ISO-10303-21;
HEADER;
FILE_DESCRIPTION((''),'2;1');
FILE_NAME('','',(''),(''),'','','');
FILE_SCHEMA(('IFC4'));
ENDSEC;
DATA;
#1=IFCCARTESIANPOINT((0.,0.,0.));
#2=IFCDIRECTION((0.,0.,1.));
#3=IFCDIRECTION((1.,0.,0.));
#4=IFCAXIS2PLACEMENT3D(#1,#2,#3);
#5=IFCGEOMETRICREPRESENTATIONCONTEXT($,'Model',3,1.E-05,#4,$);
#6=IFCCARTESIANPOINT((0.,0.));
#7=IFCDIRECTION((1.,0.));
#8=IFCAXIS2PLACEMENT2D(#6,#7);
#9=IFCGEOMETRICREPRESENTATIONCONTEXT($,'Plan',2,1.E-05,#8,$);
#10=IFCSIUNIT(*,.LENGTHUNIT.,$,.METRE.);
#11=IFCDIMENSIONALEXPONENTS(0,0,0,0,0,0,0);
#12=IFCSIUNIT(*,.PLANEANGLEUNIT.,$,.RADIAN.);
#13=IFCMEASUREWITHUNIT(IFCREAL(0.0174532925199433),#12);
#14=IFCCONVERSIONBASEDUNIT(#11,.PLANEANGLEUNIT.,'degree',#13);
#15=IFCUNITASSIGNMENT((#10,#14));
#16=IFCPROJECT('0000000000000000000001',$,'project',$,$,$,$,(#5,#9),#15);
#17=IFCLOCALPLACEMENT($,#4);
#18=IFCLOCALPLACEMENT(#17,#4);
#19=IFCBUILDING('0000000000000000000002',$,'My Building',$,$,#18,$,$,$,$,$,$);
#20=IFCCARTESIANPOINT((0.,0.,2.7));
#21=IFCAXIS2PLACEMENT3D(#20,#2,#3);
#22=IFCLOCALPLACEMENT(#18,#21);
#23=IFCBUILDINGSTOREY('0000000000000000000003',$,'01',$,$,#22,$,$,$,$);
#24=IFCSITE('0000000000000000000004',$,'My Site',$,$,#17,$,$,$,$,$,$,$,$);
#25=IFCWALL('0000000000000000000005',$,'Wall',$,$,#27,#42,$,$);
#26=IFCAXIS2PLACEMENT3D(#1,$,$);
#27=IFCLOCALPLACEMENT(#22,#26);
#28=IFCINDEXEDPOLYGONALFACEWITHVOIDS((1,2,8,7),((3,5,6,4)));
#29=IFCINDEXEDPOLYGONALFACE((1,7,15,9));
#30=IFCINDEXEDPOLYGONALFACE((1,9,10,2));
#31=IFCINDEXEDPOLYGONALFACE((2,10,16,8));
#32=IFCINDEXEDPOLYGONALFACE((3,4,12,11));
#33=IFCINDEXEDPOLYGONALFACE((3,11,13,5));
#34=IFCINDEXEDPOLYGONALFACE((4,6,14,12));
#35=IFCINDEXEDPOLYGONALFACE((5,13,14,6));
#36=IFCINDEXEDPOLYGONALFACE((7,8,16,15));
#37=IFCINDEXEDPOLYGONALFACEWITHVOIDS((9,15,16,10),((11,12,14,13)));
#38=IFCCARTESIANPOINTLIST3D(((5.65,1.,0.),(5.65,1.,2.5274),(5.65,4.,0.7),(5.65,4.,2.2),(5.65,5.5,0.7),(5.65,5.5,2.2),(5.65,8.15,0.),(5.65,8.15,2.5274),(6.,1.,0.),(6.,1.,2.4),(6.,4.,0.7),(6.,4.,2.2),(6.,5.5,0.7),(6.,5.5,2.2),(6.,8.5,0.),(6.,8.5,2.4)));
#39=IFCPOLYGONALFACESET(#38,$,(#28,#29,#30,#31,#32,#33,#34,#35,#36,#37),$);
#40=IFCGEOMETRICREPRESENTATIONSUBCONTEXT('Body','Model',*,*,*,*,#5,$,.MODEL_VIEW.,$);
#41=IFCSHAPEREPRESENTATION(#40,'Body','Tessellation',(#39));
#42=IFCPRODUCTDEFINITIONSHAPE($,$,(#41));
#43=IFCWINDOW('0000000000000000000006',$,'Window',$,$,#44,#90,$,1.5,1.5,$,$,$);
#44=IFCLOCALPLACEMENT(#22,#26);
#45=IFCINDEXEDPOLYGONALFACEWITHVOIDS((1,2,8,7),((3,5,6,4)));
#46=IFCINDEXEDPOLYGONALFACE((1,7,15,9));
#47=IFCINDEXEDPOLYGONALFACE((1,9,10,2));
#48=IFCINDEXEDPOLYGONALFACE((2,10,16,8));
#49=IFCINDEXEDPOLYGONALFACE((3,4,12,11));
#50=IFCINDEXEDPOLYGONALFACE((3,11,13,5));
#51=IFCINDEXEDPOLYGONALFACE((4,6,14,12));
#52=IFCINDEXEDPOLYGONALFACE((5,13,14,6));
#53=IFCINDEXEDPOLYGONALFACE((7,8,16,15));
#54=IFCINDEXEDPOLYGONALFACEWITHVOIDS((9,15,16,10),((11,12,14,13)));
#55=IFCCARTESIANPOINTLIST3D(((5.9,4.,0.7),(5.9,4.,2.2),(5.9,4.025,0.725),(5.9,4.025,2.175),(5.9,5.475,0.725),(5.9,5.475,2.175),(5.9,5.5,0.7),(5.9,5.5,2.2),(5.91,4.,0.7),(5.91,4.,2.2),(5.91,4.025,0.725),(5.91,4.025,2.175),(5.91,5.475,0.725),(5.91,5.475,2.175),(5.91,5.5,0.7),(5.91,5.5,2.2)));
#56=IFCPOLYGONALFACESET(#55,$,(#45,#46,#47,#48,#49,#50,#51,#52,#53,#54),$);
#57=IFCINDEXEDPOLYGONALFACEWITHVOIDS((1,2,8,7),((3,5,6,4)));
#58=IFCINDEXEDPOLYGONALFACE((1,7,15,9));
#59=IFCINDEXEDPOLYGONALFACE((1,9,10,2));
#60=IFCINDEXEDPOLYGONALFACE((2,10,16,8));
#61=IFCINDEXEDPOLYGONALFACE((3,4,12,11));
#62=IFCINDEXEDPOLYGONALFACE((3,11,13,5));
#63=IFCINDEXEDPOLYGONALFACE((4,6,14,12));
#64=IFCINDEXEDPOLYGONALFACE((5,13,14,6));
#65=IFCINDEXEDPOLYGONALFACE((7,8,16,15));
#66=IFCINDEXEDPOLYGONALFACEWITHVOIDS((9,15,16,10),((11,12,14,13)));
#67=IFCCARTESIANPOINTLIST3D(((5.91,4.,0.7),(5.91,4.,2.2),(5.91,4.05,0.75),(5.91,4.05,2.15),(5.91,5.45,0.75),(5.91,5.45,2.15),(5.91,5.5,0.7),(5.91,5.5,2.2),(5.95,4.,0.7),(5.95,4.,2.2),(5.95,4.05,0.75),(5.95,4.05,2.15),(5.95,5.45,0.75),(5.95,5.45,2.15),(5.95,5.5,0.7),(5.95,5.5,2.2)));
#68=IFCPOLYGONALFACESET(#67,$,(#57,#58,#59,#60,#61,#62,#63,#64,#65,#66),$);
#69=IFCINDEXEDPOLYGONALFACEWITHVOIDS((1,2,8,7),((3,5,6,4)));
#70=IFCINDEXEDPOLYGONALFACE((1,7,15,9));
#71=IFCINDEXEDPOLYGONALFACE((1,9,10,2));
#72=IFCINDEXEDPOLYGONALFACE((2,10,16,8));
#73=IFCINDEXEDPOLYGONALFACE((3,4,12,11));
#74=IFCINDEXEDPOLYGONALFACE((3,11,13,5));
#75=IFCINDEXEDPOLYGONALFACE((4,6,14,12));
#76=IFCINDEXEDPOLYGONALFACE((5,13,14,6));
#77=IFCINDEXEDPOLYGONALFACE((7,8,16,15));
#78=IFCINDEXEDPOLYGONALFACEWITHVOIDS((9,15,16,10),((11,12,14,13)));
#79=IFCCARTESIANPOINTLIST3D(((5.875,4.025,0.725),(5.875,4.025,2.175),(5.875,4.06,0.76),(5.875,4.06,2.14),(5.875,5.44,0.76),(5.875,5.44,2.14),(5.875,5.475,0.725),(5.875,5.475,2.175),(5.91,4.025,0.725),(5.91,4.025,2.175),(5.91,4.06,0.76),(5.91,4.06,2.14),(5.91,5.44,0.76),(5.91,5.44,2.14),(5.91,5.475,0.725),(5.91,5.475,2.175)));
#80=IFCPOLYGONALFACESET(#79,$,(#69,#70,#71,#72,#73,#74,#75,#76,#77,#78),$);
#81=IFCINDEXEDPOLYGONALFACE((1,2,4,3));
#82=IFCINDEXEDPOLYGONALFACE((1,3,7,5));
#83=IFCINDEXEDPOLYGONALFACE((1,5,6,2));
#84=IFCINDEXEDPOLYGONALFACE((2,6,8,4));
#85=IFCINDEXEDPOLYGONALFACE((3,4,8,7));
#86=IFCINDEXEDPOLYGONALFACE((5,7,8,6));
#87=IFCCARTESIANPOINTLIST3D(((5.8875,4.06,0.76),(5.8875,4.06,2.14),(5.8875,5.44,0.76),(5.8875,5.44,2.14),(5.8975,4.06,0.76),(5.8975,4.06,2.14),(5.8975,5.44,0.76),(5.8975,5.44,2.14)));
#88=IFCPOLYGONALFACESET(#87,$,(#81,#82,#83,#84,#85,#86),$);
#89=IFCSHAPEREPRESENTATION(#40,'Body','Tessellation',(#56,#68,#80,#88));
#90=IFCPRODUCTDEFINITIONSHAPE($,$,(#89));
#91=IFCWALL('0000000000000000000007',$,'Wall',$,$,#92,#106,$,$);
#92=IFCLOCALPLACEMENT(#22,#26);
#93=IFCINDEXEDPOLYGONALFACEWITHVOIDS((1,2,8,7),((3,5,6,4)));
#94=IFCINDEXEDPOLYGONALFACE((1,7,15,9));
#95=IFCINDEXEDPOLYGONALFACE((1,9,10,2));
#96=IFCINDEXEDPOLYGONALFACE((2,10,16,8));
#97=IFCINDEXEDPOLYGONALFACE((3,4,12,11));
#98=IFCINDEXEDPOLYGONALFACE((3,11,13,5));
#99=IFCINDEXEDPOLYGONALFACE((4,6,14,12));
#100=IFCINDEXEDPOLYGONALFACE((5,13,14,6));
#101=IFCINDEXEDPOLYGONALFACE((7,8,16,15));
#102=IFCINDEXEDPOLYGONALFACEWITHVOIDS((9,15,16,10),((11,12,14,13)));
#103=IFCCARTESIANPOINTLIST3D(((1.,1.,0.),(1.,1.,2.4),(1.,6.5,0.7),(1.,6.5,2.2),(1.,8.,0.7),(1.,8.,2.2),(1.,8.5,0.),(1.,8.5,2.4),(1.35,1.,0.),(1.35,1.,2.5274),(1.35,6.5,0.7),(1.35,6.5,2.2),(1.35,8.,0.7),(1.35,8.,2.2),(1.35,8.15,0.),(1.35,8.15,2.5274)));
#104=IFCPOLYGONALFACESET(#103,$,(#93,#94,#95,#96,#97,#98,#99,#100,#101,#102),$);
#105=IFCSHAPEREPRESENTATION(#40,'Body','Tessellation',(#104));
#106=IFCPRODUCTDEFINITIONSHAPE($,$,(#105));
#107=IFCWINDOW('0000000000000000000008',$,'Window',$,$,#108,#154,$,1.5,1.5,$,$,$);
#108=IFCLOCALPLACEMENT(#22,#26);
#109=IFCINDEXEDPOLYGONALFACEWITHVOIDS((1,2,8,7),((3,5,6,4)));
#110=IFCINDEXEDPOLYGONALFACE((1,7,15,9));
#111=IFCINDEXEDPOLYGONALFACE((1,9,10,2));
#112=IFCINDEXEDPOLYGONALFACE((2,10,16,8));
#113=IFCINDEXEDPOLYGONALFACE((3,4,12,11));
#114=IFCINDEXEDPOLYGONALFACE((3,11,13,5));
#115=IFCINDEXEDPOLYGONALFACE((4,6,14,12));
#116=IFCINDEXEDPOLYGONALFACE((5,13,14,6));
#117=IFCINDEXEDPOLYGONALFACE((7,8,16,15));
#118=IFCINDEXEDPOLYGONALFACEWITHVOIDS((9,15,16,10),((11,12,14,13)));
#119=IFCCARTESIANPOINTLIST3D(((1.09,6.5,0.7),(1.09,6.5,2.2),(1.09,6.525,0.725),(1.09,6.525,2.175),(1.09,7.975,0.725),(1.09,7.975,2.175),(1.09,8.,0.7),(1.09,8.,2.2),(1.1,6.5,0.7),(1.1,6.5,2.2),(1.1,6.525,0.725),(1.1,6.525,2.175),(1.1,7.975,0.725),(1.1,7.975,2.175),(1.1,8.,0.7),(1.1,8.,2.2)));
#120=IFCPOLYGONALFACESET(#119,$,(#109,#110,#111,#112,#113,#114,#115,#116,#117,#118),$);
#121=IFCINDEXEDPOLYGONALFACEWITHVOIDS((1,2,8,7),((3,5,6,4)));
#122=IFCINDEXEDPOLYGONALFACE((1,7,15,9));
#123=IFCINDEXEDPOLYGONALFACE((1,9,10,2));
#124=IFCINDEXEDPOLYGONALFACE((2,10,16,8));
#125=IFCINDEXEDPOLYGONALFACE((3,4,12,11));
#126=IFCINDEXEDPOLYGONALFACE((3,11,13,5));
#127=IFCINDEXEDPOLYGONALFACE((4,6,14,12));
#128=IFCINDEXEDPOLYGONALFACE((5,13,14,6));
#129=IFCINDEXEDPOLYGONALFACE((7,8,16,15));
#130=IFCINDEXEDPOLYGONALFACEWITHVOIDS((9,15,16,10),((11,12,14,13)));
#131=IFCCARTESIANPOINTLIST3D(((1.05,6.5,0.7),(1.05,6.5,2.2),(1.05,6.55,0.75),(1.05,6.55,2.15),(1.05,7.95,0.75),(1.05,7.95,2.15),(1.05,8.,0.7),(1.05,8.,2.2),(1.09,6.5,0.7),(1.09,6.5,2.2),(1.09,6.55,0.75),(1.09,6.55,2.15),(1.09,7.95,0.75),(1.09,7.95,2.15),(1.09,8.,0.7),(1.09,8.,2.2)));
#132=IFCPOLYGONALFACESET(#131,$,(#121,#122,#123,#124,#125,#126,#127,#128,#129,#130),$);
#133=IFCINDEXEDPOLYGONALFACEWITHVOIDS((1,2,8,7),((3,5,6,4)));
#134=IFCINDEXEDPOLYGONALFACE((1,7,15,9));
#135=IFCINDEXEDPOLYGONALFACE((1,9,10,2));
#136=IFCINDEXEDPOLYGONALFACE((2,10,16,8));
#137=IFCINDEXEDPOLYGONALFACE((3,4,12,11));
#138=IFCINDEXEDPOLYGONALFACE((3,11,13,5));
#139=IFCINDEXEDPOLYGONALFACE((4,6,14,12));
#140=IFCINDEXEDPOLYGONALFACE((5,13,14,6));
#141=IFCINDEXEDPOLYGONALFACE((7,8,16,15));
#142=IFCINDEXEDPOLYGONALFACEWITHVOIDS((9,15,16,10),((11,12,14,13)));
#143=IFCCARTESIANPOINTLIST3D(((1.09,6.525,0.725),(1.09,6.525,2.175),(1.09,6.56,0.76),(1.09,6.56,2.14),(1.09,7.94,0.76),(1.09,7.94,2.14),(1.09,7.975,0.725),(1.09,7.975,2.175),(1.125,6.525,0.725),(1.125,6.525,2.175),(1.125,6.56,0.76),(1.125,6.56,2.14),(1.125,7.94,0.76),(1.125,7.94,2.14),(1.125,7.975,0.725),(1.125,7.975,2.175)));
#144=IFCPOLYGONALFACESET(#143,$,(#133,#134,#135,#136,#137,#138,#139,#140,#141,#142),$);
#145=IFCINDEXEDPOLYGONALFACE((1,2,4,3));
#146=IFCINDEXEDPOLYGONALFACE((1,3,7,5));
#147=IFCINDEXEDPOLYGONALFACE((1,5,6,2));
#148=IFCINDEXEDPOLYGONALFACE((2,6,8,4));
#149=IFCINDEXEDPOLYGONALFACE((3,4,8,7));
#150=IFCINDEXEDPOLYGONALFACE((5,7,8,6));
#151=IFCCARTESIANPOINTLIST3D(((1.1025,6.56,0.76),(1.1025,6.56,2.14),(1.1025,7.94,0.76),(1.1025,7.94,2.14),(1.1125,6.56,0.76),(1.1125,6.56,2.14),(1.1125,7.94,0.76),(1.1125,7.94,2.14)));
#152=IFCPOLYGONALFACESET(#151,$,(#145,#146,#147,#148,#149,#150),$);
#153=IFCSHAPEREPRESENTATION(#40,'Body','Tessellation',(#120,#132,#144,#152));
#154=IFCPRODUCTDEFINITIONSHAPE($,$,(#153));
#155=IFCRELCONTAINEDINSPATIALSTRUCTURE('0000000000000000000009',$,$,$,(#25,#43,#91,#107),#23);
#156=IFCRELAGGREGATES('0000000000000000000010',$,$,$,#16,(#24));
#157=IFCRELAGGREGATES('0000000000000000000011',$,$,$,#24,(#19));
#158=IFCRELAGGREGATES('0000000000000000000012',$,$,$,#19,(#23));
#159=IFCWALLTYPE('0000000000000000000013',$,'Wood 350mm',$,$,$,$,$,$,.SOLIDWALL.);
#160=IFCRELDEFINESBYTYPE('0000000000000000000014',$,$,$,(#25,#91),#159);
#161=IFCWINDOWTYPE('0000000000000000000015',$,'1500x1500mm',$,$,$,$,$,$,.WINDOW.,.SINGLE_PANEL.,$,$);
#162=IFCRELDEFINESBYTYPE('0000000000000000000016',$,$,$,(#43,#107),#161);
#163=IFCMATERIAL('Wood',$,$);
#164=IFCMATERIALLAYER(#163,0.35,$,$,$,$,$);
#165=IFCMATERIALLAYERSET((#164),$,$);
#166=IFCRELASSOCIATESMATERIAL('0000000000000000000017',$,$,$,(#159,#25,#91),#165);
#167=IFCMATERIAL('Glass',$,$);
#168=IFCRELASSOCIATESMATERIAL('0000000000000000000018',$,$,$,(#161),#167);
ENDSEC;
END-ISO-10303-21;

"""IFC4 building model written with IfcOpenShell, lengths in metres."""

from ifc_helpers import new_model, entity, si_unit, converted_unit, frame, origin_with_axes, origin_2d_with_axis, place, context, subcontext, project, spatial, line, indexed_curve, outline, extrude, clip, halfspace, shape, source, transform, mapped, material, layer, layer_set, layer_usage, type_object, type_shapes, element, fill, save


model = new_model("IFC4")

# Units and contexts
model_context = context("Model", 3, precision=1e-05, world=origin_with_axes())
plan_context = context("Plan", 2, precision=1e-05, world=origin_2d_with_axis())
body_context_1 = subcontext(model_context, "Body", "Model", "MODEL_VIEW")
body_context_2 = subcontext(plan_context, "Body", "Plan", "PLAN_VIEW")
ifc_project = project(units=[si_unit("LENGTHUNIT", "METRE"), converted_unit("PLANEANGLEUNIT", "degree", entity("IfcReal", 0.0174532925199433), si_unit("PLANEANGLEUNIT", "RADIAN"), dimensions=[0, 0, 0, 0, 0, 0, 0])], contexts=[model_context, plan_context])

# Site, building, storey
site_placement = place(None, origin_with_axes())
site = spatial("IfcSite", under=ifc_project, at=site_placement, Name="My Site")
building_placement = place(site_placement, origin_with_axes())
building = spatial("IfcBuilding", under=site, at=building_placement, Name="My Building")
storey_placement = place(building_placement, frame((0.0, 0.0, 2.7), z_axis=(0.0, 0.0, 1.0), x_axis=(1.0, 0.0, 0.0)))
storey = spatial("IfcBuildingStorey", under=building, at=storey_placement, Name="01")

# Shared definitions
ifc_material_1 = material(Name="Wood")

# Walls, openings, windows
ifc_layer_1 = layer(ifc_material_1, 0.35)
ifc_layer_set_1 = layer_set([ifc_layer_1])
ifc_layer_usage_1 = layer_usage(ifc_layer_set_1, "AXIS2", "POSITIVE", 0.0)
wall_type = type_object("IfcWallType", Name="Wood 350mm", PredefinedType="SOLIDWALL", material=ifc_layer_set_1)
wall_1_placement = place(storey_placement, frame((6.0, 1.0, 0.0), z_axis=(0.0, 0.0, 1.0), x_axis=(0.0, 1.0, 0.0)))
wall_1 = element("IfcWall", 1, at=wall_1_placement, inside=storey, type_object=wall_type, material=ifc_layer_usage_1, Name="Wall", context=body_context_1, shape_type="Clipping", body=[
    clip(clip(extrude(outline(indexed_curve([(0.0, 0.0), (0.0, 0.35), (7.5, 0.35), (7.5, 0.0), (0.0, 0.0)], self_intersect=False)), origin_with_axes(), (0.0, 0.0, 1.0), 2.7), halfspace(frame((0.0, 0.0, 2.4), z_axis=(0.0, -0.34202, 0.939693), x_axis=(0.0, -0.939693, -0.34202)), False)), halfspace(frame((7.5, 0.0, -2.7), z_axis=(0.707107, 0.707107, 0.0), x_axis=(0.707107, -0.707107, 0.0)), False)),
])
shared_shape_1 = source(origin_with_axes(), body_context_1, "Body", "SweptSolid", [
    extrude(outline(indexed_curve([(0.0, 0.0), (1.5, 0.0), (1.5, 1.5), (0.0, 1.5)], segments=[line(1, 2, 3, 4, 1)])), frame((0.0, -0.6, 0.0), z_axis=(0.0, -1.0, 0.0), x_axis=(1.0, 0.0, 0.0)), (0.0, 0.0, -1.0), 1.2),
])
opening_1_placement = place(wall_1_placement, frame((3.0, 0.0, 0.7), z_axis=(0.0, 0.0, 1.0), x_axis=(1.0, 0.0, 0.0)))
opening_1 = element("IfcOpeningElement", 2, at=opening_1_placement, cuts=wall_1, PredefinedType="OPENING", context=body_context_1, shape_type="MappedRepresentation", body=[
    mapped(shared_shape_1, transform((0.0, 0.0, 0.0), x_axis=(1.0, 0.0, 0.0), y_axis=(0.0, 1.0, 0.0), z_axis=(0.0, 0.0, 1.0), scale=1.0)),
])
ifc_material_2 = material(Name="Glass")
window_type = type_object("IfcWindowType", Name="1500x1500mm", PartitioningType="SINGLE_PANEL", PredefinedType="WINDOW", material=ifc_material_2)
shared_shape_2 = source(origin_with_axes(), body_context_1, "Body", "SweptSolid", [
    extrude(outline(indexed_curve([(0.0, 0.0), (1.5, 0.0), (1.5, 1.5), (0.0, 1.5)], segments=[line(1, 2, 3, 4, 1)]), holes=[indexed_curve([(0.025, 0.025), (1.475, 0.025), (1.475, 1.475), (0.025, 1.475)], segments=[line(1, 2, 3, 4, 1)])]), frame((0.0, 0.09, 0.0), z_axis=(0.0, -1.0, 0.0), x_axis=(1.0, 0.0, 0.0)), (0.0, 0.0, -1.0), 0.01),
    extrude(outline(indexed_curve([(0.0, 0.0), (1.5, 0.0), (1.5, 1.5), (0.0, 1.5)], segments=[line(1, 2, 3, 4, 1)]), holes=[indexed_curve([(0.05, 0.05), (1.45, 0.05), (1.45, 1.45), (0.05, 1.45)], segments=[line(1, 2, 3, 4, 1)])]), frame((0.0, 0.05, 0.0), z_axis=(0.0, -1.0, 0.0), x_axis=(1.0, 0.0, 0.0)), (0.0, 0.0, -1.0), 0.04),
    extrude(outline(indexed_curve([(0.0, 0.0), (1.45, 0.0), (1.45, 1.45), (0.0, 1.45)], segments=[line(1, 2, 3, 4, 1)]), holes=[indexed_curve([(0.035, 0.035), (1.415, 0.035), (1.415, 1.415), (0.035, 1.415)], segments=[line(1, 2, 3, 4, 1)])]), frame((0.025, 0.09, 0.025), z_axis=(0.0, -1.0, 0.0), x_axis=(1.0, 0.0, 0.0)), (0.0, 0.0, -1.0), 0.035),
    extrude(outline(indexed_curve([(0.035, 0.035), (1.415, 0.035), (1.415, 1.415), (0.035, 1.415)], segments=[line(1, 2, 3, 4, 1)])), frame((0.025, 0.1025, 0.025), z_axis=(0.0, -1.0, 0.0), x_axis=(1.0, 0.0, 0.0)), (0.0, 0.0, -1.0), 0.01),
])
shared_shape_3 = source(origin_with_axes(), body_context_2, "Body", "Curve2D", [
    entity("IfcIndexedPolyCurve", entity("IfcCartesianPointList2D", [[0.05, 0.05], [1.45, 0.05]])),
    entity("IfcIndexedPolyCurve", entity("IfcCartesianPointList2D", [[0.0, 0.1], [0.025, 0.1], [0.025, 0.09], [0.05, 0.09], [0.05, 0.05], [0.0, 0.05]]), [entity("IfcLineIndex", [1, 2, 3, 4, 5, 6, 1])]),
    entity("IfcIndexedPolyCurve", entity("IfcCartesianPointList2D", [[1.5, 0.1], [1.475, 0.1], [1.475, 0.09], [1.45, 0.09], [1.45, 0.05], [1.5, 0.05]]), [entity("IfcLineIndex", [1, 2, 3, 4, 5, 6, 1])]),
    entity("IfcIndexedPolyCurve", entity("IfcCartesianPointList2D", [[0.025, 0.09], [0.06, 0.09], [0.06, 0.125], [0.025, 0.125]]), [entity("IfcLineIndex", [1, 2, 3, 4, 1])]),
    entity("IfcIndexedPolyCurve", entity("IfcCartesianPointList2D", [[1.475, 0.09], [1.44, 0.09], [1.44, 0.125], [1.475, 0.125]]), [entity("IfcLineIndex", [1, 2, 3, 4, 1])]),
    entity("IfcIndexedPolyCurve", entity("IfcCartesianPointList2D", [[0.06, 0.09], [1.44, 0.09]])),
    entity("IfcIndexedPolyCurve", entity("IfcCartesianPointList2D", [[0.06, 0.125], [1.44, 0.125]])),
    entity("IfcIndexedPolyCurve", entity("IfcCartesianPointList2D", [[0.06, 0.1075], [1.44, 0.1075]])),
])
type_shapes(window_type, [shared_shape_2, shared_shape_3])
window_1_placement = place(opening_1_placement, frame((0.0, 0.0, 0.0), z_axis=(0.0, 0.0, 1.0), x_axis=(1.0, 0.0, 0.0)))
window_1 = element("IfcWindow", 3, at=window_1_placement, inside=storey, type_object=window_type, Name="Window", OverallHeight=1.5, OverallWidth=1.5, shapes=[
    shape(body_context_1, "Body", "MappedRepresentation", [mapped(shared_shape_2, transform((0.0, 0.0, 0.0), x_axis=(1.0, 0.0, 0.0), y_axis=(0.0, 1.0, 0.0), z_axis=(0.0, 0.0, 1.0), scale=1.0))]),
    shape(body_context_2, "Body", "MappedRepresentation", [mapped(shared_shape_3, transform((0.0, 0.0, 0.0), x_axis=(1.0, 0.0, 0.0), y_axis=(0.0, 1.0, 0.0), z_axis=(0.0, 0.0, 1.0), scale=1.0))]),
])
fill(opening_1, window_1)
ifc_layer_usage_2 = layer_usage(ifc_layer_set_1, "AXIS2", "POSITIVE", 0.0)
wall_2_placement = place(storey_placement, frame((1.0, 8.5, 0.0), z_axis=(0.0, 0.0, 1.0), x_axis=(0.0, -1.0, 0.0)))
wall_2 = element("IfcWall", 4, at=wall_2_placement, inside=storey, type_object=wall_type, material=ifc_layer_usage_2, Name="Wall", context=body_context_1, shape_type="Clipping", body=[
    clip(clip(extrude(outline(indexed_curve([(0.0, 0.0), (0.0, 0.35), (7.5, 0.35), (7.5, 0.0), (0.0, 0.0)], self_intersect=False)), origin_with_axes(), (0.0, 0.0, 1.0), 2.7), halfspace(frame((7.5, 0.0, 2.4), z_axis=(0.0, -0.34202, 0.939693), x_axis=(0.0, 0.939693, 0.34202)), False)), halfspace(frame((0.0, 0.0, -2.7), z_axis=(-0.707106, 0.707107, 0.0), x_axis=(0.707107, 0.707106, 0.0)), False)),
])
opening_2_placement = place(wall_2_placement, frame((0.5, 0.0, 0.7), z_axis=(0.0, 0.0, 1.0), x_axis=(1.0, 0.0, 0.0)))
opening_2 = element("IfcOpeningElement", 5, at=opening_2_placement, cuts=wall_2, PredefinedType="OPENING", context=body_context_1, shape_type="MappedRepresentation", body=[
    mapped(shared_shape_1, transform((0.0, 0.0, 0.0), x_axis=(1.0, 0.0, 0.0), y_axis=(0.0, 1.0, 0.0), z_axis=(0.0, 0.0, 1.0), scale=1.0)),
])
window_2_placement = place(opening_2_placement, frame((0.0, 0.0, 0.0), z_axis=(0.0, 0.0, 1.0), x_axis=(1.0, 0.0, 0.0)))
window_2 = element("IfcWindow", 6, at=window_2_placement, inside=storey, type_object=window_type, Name="Window", OverallHeight=1.5, OverallWidth=1.5, shapes=[
    shape(body_context_1, "Body", "MappedRepresentation", [mapped(shared_shape_2, transform((0.0, 0.0, 0.0), x_axis=(1.0, 0.0, 0.0), y_axis=(0.0, 1.0, 0.0), z_axis=(0.0, 0.0, 1.0), scale=1.0))]),
    shape(body_context_2, "Body", "MappedRepresentation", [mapped(shared_shape_3, transform((0.0, 0.0, 0.0), x_axis=(1.0, 0.0, 0.0), y_axis=(0.0, 1.0, 0.0), z_axis=(0.0, 0.0, 1.0), scale=1.0))]),
])
fill(opening_2, window_2)

save(model, "model.ifc")
